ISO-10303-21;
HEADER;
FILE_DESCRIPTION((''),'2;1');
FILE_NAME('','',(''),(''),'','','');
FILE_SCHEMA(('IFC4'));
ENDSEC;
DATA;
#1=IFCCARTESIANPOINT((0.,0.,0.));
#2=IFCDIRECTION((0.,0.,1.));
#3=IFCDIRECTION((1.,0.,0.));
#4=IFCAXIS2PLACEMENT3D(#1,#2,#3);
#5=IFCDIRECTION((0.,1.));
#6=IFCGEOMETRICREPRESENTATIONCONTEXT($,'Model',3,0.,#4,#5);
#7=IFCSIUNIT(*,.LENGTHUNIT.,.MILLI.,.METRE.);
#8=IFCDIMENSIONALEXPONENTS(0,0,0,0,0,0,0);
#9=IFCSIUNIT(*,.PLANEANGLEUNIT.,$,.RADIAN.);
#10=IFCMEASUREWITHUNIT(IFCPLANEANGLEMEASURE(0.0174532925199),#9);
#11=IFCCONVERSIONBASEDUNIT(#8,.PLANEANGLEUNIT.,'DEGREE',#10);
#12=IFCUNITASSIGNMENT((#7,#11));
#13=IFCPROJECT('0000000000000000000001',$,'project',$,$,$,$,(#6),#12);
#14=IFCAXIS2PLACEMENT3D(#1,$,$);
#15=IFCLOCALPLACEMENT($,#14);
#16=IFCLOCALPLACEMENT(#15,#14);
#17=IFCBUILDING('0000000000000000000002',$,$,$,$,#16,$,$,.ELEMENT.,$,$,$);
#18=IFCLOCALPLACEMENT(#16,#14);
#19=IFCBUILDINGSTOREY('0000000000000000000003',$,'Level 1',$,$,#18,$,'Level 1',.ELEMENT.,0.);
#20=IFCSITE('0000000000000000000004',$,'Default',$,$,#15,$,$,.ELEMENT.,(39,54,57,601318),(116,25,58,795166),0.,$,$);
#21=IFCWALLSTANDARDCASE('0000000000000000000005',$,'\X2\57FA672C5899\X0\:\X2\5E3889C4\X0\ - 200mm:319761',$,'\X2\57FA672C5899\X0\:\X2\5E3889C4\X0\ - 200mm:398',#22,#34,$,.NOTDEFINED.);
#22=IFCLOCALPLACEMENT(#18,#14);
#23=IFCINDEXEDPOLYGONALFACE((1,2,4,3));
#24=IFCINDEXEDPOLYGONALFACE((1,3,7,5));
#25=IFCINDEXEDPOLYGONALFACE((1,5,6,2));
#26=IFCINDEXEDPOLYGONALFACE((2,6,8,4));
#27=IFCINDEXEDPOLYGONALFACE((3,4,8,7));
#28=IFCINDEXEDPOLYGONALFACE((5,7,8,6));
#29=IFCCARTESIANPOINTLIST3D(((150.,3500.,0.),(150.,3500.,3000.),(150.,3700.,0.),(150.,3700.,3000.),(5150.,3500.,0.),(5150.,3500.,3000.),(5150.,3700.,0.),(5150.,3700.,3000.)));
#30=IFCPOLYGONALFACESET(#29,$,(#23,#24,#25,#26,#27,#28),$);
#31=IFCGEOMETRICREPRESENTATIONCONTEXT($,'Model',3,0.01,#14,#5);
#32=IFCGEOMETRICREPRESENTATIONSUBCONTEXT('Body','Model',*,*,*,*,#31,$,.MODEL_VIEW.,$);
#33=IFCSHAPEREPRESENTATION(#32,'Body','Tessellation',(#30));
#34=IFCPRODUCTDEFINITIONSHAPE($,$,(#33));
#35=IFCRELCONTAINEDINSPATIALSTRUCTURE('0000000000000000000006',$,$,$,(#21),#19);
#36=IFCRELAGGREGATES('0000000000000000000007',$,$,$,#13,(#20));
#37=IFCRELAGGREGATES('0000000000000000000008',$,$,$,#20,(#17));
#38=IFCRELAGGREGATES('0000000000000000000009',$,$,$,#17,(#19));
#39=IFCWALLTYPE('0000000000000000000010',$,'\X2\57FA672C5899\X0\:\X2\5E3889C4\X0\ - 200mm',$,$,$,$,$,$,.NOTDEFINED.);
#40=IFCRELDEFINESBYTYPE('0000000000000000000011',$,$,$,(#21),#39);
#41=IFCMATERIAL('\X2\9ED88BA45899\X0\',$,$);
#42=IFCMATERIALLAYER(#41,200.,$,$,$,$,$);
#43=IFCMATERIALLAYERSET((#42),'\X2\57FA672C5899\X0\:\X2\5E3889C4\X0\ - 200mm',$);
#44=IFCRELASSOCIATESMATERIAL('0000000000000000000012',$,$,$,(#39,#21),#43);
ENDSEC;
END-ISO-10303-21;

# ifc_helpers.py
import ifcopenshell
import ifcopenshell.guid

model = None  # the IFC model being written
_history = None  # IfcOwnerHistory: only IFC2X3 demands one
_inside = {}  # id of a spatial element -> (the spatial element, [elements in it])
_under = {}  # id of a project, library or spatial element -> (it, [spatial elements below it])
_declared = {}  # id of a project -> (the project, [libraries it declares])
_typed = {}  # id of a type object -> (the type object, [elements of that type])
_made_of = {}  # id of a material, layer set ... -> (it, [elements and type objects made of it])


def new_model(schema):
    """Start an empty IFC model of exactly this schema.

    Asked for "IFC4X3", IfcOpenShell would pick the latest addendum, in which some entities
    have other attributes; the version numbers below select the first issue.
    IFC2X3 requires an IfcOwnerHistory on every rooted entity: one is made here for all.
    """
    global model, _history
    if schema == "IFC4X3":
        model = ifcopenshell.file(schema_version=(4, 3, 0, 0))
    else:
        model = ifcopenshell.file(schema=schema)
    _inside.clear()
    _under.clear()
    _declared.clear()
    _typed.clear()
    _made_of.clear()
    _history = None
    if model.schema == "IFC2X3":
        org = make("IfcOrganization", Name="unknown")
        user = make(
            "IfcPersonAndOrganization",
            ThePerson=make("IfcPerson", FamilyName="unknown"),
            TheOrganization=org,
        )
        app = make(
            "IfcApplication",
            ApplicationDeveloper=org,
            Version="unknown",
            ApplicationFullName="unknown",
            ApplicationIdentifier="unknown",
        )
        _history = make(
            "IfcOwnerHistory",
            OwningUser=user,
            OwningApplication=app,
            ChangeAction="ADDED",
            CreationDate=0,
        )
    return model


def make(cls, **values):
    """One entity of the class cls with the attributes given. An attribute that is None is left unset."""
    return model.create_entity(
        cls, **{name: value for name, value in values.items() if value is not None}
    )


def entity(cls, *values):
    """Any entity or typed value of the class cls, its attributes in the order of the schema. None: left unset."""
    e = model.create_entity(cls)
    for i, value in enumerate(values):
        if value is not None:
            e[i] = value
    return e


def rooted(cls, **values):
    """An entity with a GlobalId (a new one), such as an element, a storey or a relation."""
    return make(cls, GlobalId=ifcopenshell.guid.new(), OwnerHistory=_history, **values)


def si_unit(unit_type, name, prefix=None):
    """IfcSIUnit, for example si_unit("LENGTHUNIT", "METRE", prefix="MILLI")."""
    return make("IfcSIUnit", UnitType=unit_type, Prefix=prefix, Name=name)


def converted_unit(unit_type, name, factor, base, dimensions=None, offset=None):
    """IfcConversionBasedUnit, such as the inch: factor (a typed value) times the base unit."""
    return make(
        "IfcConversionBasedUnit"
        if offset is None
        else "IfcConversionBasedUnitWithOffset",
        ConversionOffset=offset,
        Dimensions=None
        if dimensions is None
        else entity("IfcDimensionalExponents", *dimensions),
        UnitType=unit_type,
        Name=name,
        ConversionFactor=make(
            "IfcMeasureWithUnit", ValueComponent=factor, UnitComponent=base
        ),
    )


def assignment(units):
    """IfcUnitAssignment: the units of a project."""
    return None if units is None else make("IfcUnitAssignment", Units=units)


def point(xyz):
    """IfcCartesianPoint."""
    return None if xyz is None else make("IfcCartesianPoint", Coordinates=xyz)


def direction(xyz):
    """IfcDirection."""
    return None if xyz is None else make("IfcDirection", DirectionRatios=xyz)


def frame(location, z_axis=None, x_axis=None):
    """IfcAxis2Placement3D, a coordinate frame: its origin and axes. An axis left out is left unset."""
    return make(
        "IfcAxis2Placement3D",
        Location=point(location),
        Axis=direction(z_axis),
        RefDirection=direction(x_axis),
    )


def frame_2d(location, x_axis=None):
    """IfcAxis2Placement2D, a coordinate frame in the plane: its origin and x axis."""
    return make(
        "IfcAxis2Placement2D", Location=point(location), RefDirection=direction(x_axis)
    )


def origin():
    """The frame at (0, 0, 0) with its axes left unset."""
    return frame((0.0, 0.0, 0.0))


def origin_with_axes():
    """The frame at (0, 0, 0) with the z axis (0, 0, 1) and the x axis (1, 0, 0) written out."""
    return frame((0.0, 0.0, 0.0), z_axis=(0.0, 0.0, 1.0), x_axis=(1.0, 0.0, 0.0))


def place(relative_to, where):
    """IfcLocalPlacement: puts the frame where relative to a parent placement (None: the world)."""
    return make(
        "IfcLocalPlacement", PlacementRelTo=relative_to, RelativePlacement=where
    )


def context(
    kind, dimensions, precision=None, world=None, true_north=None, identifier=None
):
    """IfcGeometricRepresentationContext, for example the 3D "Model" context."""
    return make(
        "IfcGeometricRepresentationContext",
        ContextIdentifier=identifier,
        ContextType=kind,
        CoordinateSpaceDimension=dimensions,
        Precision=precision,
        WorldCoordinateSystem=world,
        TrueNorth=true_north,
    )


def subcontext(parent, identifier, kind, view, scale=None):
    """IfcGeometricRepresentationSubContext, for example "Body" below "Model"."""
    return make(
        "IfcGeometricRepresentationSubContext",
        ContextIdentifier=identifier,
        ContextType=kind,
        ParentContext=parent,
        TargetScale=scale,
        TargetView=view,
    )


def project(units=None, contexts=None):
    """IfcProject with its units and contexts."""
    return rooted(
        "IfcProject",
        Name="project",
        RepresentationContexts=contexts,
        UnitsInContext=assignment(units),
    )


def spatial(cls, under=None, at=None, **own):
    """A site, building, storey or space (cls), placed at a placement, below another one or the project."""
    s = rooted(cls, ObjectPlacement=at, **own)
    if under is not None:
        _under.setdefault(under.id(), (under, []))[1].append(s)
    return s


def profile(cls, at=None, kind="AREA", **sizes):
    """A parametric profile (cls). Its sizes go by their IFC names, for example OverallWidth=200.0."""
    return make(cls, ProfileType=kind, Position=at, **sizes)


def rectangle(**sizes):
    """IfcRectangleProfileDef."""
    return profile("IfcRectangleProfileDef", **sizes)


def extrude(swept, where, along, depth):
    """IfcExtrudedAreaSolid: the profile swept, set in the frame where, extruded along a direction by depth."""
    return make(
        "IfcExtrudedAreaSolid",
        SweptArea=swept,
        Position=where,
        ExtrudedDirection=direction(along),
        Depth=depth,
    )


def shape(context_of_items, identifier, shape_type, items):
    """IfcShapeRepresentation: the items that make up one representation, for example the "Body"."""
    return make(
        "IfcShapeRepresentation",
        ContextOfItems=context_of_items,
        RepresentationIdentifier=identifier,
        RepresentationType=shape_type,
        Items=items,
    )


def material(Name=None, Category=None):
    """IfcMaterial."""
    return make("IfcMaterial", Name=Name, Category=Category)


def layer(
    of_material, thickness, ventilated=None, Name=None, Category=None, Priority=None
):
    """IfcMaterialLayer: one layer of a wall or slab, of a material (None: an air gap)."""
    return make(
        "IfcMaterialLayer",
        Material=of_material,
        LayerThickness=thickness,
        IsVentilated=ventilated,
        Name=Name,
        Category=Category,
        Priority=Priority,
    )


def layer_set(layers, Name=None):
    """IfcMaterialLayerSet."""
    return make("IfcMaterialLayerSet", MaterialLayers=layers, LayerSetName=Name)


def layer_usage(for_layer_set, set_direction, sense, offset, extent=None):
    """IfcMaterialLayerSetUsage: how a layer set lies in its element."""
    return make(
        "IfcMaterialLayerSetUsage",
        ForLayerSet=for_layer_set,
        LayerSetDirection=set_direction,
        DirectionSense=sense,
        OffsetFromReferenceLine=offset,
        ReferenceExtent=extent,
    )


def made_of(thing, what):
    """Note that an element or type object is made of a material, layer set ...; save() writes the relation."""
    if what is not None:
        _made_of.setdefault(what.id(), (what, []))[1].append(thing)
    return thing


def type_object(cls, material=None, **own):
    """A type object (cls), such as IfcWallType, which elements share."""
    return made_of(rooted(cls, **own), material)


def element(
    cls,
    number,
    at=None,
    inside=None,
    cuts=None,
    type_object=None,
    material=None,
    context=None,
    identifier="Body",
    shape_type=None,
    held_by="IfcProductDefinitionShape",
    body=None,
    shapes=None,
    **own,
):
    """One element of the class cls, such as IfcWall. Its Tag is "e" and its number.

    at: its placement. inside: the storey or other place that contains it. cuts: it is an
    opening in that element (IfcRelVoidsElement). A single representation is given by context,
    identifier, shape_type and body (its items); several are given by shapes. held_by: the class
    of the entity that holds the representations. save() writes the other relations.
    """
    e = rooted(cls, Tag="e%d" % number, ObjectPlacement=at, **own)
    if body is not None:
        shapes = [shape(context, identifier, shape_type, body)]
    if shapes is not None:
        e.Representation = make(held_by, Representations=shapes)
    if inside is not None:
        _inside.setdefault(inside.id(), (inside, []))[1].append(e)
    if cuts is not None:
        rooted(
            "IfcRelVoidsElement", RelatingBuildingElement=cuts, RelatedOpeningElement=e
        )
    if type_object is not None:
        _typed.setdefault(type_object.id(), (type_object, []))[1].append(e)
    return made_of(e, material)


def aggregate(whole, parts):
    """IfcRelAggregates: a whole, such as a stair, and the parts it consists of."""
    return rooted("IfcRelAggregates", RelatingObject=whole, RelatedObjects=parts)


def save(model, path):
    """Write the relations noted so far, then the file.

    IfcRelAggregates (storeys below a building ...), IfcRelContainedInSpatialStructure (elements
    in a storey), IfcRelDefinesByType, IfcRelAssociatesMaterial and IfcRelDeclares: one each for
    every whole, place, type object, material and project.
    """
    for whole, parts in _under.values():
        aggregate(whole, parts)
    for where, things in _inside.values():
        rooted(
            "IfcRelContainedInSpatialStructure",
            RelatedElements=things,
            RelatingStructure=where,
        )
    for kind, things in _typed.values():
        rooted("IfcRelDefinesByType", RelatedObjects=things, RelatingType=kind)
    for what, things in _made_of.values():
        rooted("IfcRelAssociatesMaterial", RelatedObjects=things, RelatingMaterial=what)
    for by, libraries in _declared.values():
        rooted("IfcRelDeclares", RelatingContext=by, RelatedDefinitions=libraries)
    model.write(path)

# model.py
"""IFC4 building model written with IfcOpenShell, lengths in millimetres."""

from ifc_helpers import new_model, entity, si_unit, converted_unit, direction, frame, frame_2d, origin, origin_with_axes, place, context, subcontext, project, spatial, rectangle, extrude, material, layer, layer_set, layer_usage, type_object, element, save


model = new_model("IFC4")

# Units and contexts
model_context_1 = context("Model", 3, precision=0.0, world=origin_with_axes(), true_north=direction((0.0, 1.0)))
model_context_2 = context("Model", 3, precision=0.01, world=origin(), true_north=direction((0.0, 1.0)))
body_context = subcontext(model_context_2, "Body", "Model", "MODEL_VIEW")
ifc_project = project(units=[si_unit("LENGTHUNIT", "METRE", prefix="MILLI"), converted_unit("PLANEANGLEUNIT", "DEGREE", entity("IfcPlaneAngleMeasure", 0.0174532925199), si_unit("PLANEANGLEUNIT", "RADIAN"), dimensions=[0, 0, 0, 0, 0, 0, 0])], contexts=[model_context_1])

# Site, building, storey
site_placement = place(None, origin())
site = spatial("IfcSite", under=ifc_project, at=site_placement, Name="Default", CompositionType="ELEMENT", RefLatitude=(39, 54, 57, 601318), RefLongitude=(116, 25, 58, 795166), RefElevation=0.0)
building_placement = place(site_placement, origin())
building = spatial("IfcBuilding", under=site, at=building_placement, CompositionType="ELEMENT")
storey_placement = place(building_placement, origin())
storey = spatial("IfcBuildingStorey", under=building, at=storey_placement, Name="Level 1", LongName="Level 1", CompositionType="ELEMENT", Elevation=0.0)

# Shared definitions
ifc_material_1 = material(Name="默认墙")
ifc_layer = layer(ifc_material_1, 200.0)
ifc_layer_set = layer_set([ifc_layer], Name="基本墙:常规 - 200mm")
wall_type = type_object("IfcWallType", Name="基本墙:常规 - 200mm", PredefinedType="NOTDEFINED", material=ifc_layer_set)

# Wall
ifc_layer_usage_1 = layer_usage(ifc_layer_set, "AXIS2", "NEGATIVE", 100.0)
wall_1_placement = place(storey_placement, frame((150.0, 3600.0, 0.0)))
element("IfcWallStandardCase", 1, at=wall_1_placement, inside=storey, type_object=wall_type, material=ifc_layer_usage_1, Name="基本墙:常规 - 200mm:319761", ObjectType="基本墙:常规 - 200mm:398", PredefinedType="NOTDEFINED", context=body_context, shape_type="SweptSolid", body=[
    extrude(rectangle(XDim=5000.0, YDim=200.0, at=frame_2d((2500.0, 0.0), x_axis=(-1.0, 0.0))), origin(), (0.0, 0.0, 1.0), 3000.0),
])

save(model, "model.ifc")
